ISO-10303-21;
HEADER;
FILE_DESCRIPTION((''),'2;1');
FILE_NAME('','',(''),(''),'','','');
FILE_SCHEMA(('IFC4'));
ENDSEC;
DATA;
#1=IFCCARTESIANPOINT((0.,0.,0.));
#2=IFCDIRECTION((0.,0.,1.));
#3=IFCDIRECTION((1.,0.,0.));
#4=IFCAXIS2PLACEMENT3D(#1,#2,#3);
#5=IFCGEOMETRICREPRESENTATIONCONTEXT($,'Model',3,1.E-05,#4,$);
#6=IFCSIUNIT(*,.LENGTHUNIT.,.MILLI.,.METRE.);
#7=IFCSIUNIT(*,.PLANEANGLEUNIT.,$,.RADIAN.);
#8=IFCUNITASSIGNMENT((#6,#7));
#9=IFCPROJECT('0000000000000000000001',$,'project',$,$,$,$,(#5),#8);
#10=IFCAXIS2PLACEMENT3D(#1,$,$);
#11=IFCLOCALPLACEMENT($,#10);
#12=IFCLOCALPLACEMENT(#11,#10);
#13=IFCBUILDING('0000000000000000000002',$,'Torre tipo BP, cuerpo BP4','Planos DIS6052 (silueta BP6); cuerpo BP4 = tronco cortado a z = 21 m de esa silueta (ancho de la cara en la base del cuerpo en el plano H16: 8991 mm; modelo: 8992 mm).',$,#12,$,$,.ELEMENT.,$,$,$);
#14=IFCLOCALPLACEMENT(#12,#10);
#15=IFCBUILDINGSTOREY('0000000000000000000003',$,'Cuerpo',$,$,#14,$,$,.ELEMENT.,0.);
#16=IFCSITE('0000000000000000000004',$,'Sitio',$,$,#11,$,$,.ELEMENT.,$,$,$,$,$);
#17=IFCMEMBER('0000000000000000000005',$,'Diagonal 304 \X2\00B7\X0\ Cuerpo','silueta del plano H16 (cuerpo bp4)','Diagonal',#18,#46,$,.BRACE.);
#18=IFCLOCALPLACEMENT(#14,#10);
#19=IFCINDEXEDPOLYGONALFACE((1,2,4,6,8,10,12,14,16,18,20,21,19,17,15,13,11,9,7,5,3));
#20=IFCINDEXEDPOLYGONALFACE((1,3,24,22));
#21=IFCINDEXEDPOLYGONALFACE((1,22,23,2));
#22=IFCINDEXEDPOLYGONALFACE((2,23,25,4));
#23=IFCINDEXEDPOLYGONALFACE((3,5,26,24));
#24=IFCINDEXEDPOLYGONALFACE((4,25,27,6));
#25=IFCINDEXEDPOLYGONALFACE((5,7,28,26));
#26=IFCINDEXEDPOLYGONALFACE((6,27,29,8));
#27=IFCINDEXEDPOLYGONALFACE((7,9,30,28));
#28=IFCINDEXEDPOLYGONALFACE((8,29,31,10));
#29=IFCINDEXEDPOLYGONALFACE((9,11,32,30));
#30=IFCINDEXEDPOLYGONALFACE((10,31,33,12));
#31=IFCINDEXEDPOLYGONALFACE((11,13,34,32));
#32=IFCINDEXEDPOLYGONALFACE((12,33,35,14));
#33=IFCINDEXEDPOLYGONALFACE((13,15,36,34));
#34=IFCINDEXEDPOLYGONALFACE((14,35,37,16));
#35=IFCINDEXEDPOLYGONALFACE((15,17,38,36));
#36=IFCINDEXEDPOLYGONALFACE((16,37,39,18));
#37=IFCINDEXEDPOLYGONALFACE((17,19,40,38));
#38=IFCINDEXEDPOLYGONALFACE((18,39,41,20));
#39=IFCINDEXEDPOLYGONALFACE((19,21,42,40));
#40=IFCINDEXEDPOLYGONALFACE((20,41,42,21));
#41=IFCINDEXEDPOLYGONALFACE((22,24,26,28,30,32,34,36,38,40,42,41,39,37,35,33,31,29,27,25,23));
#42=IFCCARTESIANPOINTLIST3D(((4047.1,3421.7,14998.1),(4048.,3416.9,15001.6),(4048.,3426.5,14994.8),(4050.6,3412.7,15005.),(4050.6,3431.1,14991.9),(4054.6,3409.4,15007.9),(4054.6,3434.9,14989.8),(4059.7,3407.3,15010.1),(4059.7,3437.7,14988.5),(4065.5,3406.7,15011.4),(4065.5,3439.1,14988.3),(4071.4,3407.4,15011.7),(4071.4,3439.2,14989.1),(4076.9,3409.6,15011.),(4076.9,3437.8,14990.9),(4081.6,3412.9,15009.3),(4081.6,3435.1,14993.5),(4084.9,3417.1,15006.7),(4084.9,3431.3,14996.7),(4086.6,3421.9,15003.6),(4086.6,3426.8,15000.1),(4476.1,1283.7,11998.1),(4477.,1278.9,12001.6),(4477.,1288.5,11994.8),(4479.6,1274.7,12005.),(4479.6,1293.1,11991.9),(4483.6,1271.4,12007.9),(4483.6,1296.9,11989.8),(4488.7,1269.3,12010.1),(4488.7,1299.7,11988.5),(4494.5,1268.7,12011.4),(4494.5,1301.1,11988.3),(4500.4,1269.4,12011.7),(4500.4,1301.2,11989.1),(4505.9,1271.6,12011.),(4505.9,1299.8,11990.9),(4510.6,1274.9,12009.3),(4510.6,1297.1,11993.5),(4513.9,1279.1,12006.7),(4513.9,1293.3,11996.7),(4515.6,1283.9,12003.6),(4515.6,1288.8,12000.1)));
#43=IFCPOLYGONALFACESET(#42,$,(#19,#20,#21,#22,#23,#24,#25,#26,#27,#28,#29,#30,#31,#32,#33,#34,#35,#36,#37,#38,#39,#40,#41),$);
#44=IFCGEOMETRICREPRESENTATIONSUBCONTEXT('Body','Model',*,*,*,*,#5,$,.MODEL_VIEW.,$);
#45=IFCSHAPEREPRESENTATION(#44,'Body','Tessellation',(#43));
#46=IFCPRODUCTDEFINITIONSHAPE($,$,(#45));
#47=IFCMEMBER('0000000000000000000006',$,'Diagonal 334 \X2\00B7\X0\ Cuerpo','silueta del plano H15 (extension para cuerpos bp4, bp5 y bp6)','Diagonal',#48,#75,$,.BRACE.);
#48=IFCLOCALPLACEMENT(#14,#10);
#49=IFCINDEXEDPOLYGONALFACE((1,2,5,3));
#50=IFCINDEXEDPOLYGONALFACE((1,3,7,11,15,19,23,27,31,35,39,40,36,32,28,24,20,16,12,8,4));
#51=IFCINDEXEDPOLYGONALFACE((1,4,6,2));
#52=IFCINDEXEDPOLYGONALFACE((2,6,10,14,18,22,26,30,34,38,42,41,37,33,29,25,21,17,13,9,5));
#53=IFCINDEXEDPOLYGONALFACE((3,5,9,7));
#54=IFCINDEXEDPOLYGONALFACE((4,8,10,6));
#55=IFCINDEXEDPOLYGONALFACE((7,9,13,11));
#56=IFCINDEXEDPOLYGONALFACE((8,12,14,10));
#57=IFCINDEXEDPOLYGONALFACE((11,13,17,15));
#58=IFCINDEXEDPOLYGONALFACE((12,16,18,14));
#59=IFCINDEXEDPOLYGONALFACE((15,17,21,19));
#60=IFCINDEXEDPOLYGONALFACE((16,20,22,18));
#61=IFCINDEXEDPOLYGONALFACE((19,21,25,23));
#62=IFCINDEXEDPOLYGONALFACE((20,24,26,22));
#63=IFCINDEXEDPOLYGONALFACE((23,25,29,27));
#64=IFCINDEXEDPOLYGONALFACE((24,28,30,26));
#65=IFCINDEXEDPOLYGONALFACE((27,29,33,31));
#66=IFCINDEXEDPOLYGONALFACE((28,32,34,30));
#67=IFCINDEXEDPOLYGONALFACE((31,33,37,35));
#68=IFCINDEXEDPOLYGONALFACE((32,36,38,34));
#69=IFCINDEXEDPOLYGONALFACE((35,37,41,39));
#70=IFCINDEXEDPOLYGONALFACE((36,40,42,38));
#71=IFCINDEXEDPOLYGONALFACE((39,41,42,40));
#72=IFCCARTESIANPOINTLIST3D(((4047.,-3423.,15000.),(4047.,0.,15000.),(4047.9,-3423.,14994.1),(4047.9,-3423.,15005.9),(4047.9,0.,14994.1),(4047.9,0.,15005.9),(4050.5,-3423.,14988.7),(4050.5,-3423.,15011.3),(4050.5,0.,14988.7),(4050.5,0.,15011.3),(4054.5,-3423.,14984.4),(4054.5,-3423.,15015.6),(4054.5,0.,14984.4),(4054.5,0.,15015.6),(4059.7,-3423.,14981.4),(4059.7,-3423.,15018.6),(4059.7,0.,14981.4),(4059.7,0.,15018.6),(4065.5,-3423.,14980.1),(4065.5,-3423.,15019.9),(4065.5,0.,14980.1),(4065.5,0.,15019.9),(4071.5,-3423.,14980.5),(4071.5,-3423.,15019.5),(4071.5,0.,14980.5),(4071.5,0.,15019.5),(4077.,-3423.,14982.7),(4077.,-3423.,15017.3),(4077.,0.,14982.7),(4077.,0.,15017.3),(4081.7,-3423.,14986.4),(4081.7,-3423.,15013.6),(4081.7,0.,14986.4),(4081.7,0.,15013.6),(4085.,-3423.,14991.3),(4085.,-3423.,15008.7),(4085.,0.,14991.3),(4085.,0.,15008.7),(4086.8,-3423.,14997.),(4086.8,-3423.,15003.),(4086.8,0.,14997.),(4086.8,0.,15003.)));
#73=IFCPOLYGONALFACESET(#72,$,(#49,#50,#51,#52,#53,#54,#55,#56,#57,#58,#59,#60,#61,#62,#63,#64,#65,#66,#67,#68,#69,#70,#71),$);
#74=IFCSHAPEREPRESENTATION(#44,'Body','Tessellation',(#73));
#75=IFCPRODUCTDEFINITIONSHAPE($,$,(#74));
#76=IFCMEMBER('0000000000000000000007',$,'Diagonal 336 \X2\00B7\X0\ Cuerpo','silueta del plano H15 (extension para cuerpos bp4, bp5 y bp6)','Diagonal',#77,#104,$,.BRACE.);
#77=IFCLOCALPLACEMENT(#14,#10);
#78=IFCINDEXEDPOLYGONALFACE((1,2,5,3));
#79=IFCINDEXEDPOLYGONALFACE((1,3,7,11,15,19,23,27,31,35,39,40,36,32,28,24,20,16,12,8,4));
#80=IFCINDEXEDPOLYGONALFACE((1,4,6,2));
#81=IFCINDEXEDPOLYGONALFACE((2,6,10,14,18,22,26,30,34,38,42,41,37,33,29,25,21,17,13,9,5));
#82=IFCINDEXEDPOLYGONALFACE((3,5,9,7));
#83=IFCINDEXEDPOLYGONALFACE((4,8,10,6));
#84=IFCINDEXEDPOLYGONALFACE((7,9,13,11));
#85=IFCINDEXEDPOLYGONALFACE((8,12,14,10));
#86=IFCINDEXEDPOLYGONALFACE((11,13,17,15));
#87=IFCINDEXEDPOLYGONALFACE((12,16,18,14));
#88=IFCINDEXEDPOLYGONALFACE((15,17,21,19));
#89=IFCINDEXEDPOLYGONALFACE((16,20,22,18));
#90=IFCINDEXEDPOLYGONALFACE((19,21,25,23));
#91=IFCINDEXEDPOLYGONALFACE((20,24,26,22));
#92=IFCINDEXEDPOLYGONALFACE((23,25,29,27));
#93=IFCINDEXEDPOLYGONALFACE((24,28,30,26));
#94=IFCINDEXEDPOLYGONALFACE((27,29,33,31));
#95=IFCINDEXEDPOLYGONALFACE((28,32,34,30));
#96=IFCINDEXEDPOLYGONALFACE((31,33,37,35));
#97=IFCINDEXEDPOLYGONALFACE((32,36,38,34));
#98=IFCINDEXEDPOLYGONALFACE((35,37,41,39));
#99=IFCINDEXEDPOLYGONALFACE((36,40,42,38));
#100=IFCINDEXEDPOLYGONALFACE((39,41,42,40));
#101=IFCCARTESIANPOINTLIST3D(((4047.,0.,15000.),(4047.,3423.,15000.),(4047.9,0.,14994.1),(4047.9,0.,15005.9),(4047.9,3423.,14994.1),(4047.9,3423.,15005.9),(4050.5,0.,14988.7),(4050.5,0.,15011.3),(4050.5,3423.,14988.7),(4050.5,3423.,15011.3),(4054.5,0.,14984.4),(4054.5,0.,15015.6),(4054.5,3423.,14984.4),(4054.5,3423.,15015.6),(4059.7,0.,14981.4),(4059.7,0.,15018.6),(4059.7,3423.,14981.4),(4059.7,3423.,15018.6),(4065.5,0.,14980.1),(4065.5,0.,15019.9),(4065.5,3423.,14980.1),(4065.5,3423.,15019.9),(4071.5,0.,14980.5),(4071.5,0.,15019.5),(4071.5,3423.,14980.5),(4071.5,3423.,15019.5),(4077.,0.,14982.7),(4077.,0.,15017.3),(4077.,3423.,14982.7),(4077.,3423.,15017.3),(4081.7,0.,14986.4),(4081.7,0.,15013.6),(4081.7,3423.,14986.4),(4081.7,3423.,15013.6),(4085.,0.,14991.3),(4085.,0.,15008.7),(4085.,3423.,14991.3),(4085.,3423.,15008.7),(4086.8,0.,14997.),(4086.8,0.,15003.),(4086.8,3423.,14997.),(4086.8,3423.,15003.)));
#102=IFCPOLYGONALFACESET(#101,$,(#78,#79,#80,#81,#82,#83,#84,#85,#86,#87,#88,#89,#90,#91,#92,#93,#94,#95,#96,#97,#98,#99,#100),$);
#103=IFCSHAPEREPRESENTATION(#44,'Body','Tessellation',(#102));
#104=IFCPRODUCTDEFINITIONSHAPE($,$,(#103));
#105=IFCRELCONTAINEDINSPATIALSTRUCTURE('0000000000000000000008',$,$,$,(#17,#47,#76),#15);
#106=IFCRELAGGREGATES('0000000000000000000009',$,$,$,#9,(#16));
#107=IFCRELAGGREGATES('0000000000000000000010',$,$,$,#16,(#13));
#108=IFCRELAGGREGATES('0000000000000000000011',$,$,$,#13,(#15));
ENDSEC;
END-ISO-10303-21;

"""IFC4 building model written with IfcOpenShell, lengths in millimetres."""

from ifc_helpers import new_model, si_unit, frame, origin, origin_with_axes, place, context, subcontext, project, spatial, circle, extrude, element, save


model = new_model("IFC4")

# Units and contexts
model_context = context("Model", 3, precision=1e-05, world=origin_with_axes())
body_context = subcontext(model_context, "Body", "Model", "MODEL_VIEW")
ifc_project = project(units=[si_unit("LENGTHUNIT", "METRE", prefix="MILLI"), si_unit("PLANEANGLEUNIT", "RADIAN")], contexts=[model_context])

# Site, building, storey
site_placement = place(None, origin())
site = spatial("IfcSite", under=ifc_project, at=site_placement, Name="Sitio", CompositionType="ELEMENT")
building_placement = place(site_placement, origin())
building = spatial("IfcBuilding", under=site, at=building_placement, Name="Torre tipo BP, cuerpo BP4", Description="Planos DIS6052 (silueta BP6); cuerpo BP4 = tronco cortado a z = 21 m de esa silueta (ancho de la cara en la base del cuerpo en el plano H16: 8991 mm; modelo: 8992 mm).", CompositionType="ELEMENT")
storey_placement = place(building_placement, origin())
storey = spatial("IfcBuildingStorey", under=building, at=storey_placement, Name="Cuerpo", CompositionType="ELEMENT", Elevation=0.0)

# Members
for number, where, z_axis, x_axis, name in (
    (1, (4067.0, 3423.0, 15000.0), (0.115671, -0.576469, -0.80889), (-0.993288, -0.067132, -0.094198), "Diagonal 304 · Cuerpo"),
):
    element("IfcMember", number, at=place(storey_placement, frame(where, z_axis=z_axis, x_axis=x_axis)), inside=storey, Name=name, Description="silueta del plano H16 (cuerpo bp4)", ObjectType="Diagonal", PredefinedType="BRACE", context=body_context, shape_type="SweptSolid", body=[
        extrude(circle(Radius=20.0), None, (0.0, 0.0, 1.0), 3708.8),
    ])
for number, where, z_axis, x_axis, name in (
    (2, (4067.0, -3423.0, 15000.0), (0.0, 1.0, 0.0), (-1.0, 0.0, 0.0), "Diagonal 334 · Cuerpo"),
    (3, (4067.0, 3423.0, 15000.0), (0.0, -1.0, 0.0), (-1.0, 0.0, 0.0), "Diagonal 336 · Cuerpo"),
):
    element("IfcMember", number, at=place(storey_placement, frame(where, z_axis=z_axis, x_axis=x_axis)), inside=storey, Name=name, Description="silueta del plano H15 (extension para cuerpos bp4, bp5 y bp6)", ObjectType="Diagonal", PredefinedType="BRACE", context=body_context, shape_type="SweptSolid", body=[
        extrude(circle(Radius=20.0), None, (0.0, 0.0, 1.0), 3423.0),
    ])

save(model, "model.ifc")
